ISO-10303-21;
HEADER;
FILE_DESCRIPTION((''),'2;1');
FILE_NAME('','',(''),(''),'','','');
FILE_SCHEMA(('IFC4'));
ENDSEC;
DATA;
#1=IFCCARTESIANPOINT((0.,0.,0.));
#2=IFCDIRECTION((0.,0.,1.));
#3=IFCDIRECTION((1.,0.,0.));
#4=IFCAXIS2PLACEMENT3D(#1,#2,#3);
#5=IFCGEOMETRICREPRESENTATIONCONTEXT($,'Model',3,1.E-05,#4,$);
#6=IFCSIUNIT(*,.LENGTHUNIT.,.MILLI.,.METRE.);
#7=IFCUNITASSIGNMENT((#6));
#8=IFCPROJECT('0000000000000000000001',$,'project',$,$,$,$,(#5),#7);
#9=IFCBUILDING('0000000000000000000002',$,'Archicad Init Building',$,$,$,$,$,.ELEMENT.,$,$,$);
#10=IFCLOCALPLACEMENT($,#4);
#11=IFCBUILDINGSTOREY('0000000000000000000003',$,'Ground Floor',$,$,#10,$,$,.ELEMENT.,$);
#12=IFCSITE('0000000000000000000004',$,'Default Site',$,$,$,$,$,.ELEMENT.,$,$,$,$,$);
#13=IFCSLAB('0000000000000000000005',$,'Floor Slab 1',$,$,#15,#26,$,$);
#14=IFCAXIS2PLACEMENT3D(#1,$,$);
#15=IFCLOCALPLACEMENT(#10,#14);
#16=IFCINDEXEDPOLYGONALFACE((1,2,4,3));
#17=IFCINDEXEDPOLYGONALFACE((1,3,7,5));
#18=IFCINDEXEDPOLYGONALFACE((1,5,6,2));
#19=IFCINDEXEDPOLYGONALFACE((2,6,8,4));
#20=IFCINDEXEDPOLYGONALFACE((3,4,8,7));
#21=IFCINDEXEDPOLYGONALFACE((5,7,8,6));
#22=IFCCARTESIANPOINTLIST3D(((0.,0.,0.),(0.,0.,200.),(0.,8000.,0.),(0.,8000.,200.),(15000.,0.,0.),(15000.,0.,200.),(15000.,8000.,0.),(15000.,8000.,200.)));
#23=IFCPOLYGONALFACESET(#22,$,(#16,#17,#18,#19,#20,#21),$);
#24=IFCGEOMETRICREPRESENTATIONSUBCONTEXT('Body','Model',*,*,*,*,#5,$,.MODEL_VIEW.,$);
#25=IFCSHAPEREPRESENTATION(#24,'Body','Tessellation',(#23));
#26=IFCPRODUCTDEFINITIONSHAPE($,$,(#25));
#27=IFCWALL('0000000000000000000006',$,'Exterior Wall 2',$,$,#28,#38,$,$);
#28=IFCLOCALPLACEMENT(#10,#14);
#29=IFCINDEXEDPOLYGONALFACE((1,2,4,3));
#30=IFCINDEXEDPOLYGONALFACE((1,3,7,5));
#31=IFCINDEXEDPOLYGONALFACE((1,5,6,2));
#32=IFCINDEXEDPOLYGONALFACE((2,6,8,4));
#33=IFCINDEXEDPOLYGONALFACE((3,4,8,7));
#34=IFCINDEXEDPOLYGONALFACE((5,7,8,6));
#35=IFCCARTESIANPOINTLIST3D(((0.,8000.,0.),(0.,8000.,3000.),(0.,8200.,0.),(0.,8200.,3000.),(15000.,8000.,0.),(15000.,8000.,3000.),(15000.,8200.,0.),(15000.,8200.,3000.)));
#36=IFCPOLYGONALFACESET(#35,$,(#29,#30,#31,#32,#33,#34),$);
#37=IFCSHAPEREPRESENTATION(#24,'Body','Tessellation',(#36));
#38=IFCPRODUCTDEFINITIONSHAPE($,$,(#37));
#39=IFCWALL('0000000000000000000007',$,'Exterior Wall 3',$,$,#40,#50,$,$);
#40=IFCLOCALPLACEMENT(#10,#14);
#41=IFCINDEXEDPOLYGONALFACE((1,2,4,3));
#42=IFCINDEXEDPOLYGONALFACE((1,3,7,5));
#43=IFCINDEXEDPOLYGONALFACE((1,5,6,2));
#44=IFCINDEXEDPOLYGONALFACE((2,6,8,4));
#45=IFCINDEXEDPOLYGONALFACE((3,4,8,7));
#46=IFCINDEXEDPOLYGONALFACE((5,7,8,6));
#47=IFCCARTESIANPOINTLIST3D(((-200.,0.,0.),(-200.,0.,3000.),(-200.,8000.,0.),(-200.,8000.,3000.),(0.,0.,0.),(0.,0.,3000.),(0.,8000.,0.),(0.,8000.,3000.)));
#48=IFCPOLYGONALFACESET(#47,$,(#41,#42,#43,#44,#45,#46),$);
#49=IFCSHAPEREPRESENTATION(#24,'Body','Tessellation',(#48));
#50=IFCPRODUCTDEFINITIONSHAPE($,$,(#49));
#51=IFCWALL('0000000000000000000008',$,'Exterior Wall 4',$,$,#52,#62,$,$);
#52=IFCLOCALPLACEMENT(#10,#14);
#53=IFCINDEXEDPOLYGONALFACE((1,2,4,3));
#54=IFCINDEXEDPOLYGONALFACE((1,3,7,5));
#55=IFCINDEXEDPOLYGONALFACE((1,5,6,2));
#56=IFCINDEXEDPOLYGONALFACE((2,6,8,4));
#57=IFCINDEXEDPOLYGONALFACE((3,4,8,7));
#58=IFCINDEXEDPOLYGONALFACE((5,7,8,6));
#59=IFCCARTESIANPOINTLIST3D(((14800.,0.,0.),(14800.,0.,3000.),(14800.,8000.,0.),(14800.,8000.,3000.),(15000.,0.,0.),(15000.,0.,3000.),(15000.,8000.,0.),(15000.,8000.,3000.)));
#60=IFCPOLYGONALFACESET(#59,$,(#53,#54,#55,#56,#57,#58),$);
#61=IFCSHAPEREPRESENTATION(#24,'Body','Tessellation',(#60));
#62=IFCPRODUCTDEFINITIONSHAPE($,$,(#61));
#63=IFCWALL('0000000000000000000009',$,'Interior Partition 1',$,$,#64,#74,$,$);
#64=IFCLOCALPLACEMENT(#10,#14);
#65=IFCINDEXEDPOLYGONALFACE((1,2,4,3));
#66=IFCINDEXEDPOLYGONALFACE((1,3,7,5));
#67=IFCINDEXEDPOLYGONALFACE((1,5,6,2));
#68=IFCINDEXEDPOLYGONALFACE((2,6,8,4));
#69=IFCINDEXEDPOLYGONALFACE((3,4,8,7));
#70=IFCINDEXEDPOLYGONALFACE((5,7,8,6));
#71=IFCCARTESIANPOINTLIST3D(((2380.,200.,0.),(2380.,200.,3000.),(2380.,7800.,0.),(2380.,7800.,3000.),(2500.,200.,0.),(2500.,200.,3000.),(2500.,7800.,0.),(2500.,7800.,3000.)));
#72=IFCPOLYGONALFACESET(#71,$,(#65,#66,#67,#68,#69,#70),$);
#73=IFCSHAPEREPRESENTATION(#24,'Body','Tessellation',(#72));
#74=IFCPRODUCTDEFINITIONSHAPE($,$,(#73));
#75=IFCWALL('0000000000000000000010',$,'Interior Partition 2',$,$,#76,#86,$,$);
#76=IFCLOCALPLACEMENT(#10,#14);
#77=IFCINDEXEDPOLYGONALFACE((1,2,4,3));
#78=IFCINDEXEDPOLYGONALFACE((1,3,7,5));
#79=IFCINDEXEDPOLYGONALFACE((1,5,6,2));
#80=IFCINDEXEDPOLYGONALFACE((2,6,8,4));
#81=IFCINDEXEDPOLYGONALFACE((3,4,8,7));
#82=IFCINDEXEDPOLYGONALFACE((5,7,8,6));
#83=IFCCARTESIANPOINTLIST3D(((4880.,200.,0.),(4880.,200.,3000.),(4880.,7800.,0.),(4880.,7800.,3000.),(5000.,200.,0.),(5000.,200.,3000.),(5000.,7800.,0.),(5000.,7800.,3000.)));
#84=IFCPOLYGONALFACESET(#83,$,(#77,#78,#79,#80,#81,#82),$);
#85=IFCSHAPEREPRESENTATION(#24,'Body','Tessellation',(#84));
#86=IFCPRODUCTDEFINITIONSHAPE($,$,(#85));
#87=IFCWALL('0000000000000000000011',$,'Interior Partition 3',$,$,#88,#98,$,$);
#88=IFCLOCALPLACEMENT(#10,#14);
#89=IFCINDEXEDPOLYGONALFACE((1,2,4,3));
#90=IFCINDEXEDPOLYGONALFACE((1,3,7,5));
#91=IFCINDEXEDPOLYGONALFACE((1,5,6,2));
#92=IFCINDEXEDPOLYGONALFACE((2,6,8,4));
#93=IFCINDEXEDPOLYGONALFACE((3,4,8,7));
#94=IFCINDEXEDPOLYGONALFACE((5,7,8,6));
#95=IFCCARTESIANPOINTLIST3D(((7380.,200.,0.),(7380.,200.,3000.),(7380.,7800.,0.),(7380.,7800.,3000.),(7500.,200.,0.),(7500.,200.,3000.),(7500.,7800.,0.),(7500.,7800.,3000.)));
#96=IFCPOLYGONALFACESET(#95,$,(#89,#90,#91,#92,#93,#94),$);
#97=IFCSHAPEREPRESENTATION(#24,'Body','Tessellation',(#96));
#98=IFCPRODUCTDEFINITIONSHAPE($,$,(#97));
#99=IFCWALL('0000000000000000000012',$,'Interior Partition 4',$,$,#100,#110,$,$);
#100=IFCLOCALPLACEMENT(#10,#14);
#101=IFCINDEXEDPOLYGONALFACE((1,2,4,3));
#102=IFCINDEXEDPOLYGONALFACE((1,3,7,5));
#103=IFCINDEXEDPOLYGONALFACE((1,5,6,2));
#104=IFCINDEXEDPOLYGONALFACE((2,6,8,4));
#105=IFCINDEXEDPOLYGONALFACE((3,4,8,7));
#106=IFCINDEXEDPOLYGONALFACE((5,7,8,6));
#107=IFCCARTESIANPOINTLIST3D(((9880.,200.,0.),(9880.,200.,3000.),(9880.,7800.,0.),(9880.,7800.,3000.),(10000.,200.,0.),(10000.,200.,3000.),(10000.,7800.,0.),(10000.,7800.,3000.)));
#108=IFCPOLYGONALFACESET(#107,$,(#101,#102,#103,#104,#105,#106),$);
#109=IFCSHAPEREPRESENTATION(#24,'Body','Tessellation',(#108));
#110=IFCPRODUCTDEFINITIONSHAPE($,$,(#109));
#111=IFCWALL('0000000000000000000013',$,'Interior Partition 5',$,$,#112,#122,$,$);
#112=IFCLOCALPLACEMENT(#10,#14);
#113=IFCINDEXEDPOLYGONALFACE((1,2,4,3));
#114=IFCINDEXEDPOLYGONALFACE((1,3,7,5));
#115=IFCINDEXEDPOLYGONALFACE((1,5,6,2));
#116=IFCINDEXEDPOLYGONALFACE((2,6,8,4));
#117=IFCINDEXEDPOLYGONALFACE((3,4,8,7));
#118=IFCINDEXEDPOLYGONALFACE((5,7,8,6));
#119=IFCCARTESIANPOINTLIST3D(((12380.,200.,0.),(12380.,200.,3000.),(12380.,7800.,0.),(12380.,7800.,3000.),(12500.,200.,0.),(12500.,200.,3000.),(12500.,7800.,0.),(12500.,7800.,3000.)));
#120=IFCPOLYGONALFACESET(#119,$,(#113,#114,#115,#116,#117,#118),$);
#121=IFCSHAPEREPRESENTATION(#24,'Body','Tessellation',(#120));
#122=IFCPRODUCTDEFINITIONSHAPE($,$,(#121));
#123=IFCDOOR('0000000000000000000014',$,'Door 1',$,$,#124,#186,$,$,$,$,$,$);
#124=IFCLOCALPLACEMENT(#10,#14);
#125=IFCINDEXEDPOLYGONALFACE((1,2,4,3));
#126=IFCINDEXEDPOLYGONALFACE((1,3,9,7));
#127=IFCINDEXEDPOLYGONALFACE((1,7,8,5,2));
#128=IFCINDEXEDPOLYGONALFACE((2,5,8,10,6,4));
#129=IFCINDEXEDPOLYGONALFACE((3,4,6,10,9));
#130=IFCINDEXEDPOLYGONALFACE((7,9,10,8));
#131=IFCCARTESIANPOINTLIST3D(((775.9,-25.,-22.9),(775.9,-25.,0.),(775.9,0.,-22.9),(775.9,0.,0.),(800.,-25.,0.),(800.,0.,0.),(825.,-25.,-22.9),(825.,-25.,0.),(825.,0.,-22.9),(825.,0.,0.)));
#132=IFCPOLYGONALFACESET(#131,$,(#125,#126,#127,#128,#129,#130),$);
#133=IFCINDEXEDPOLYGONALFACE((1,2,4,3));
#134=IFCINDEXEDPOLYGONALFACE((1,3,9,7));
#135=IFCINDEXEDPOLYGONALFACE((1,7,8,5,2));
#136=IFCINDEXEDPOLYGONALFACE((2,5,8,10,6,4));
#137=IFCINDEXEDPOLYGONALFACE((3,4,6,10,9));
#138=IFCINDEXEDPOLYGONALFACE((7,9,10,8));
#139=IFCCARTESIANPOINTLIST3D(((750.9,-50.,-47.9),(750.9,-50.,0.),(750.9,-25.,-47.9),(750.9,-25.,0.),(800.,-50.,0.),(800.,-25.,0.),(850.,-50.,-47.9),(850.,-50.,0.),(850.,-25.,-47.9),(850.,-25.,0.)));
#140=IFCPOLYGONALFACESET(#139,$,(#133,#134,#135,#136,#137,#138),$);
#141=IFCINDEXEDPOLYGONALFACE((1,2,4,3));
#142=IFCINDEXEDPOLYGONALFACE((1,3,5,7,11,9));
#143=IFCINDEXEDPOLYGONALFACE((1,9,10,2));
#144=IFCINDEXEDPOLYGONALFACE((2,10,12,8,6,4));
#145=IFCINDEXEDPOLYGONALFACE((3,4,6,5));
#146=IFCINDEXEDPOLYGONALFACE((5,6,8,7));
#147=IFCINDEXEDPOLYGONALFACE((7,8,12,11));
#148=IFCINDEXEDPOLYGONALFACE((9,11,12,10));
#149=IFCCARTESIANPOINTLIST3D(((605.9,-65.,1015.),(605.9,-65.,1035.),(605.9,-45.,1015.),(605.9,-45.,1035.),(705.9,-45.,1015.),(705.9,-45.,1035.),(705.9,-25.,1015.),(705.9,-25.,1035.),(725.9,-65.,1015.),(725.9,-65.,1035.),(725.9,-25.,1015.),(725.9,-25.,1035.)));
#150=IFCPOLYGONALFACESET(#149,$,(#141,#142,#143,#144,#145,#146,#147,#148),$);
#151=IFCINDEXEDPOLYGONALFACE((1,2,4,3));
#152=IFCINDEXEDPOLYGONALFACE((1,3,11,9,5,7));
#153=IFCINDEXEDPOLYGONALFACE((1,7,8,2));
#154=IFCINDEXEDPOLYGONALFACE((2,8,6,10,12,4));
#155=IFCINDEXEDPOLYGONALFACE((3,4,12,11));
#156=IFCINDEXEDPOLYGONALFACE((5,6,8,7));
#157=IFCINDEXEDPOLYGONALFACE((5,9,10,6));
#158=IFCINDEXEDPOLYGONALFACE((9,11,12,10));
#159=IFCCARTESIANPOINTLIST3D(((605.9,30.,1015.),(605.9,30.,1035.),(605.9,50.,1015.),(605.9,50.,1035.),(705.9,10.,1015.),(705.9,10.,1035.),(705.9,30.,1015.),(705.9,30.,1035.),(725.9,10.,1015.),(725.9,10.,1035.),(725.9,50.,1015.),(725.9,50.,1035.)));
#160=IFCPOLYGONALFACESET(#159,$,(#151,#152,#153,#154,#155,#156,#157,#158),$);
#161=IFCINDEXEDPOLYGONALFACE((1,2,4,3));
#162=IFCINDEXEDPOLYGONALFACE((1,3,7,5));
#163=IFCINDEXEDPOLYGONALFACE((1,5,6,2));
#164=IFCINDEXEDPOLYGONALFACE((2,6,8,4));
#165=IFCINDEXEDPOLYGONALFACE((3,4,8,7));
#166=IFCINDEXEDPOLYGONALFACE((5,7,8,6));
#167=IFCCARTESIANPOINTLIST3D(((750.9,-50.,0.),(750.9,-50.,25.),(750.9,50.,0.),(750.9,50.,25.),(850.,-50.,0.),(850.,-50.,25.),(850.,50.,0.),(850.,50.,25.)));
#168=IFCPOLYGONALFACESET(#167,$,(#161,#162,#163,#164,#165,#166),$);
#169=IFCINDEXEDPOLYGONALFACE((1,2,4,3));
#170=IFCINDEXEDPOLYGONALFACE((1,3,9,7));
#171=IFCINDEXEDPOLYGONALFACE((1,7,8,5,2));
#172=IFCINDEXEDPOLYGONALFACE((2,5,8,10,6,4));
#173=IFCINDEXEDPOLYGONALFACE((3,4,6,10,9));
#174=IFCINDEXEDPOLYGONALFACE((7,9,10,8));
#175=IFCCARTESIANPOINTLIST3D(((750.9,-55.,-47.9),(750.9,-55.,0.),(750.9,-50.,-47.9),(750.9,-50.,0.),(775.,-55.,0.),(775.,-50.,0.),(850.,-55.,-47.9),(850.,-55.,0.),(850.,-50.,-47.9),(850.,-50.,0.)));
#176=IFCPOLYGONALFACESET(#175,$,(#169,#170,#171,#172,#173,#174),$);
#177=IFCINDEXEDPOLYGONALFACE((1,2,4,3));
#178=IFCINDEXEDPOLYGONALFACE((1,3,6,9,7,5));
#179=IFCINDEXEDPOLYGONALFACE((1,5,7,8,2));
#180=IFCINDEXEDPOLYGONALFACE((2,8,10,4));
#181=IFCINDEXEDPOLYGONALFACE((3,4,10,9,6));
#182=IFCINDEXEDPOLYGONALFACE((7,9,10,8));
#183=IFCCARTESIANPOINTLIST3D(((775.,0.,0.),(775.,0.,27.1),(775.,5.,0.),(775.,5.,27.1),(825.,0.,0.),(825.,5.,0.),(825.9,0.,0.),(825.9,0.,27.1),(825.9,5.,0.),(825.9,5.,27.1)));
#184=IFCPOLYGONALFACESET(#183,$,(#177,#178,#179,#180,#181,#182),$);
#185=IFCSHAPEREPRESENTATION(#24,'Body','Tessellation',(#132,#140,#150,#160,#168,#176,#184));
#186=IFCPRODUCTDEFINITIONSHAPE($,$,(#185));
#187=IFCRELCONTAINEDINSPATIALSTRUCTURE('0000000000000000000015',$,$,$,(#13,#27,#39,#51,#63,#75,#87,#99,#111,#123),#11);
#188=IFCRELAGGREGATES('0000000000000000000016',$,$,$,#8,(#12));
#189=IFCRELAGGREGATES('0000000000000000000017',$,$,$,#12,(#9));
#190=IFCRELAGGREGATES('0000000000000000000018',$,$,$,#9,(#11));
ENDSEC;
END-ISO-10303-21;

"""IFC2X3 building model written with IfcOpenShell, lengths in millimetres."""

from ifc_helpers import new_model, si_unit, frame, origin_with_axes, place, context, subcontext, project, spatial, polyline, outline, extrude, element, save


model = new_model("IFC2X3")

# Units and contexts
model_context = context("Model", 3, precision=1e-05, world=origin_with_axes())
body_context = subcontext(model_context, "Body", "Model", "MODEL_VIEW")
ifc_project = project(units=[si_unit("LENGTHUNIT", "METRE", prefix="MILLI")], contexts=[model_context])

# Site, building, storey
site = spatial("IfcSite", under=ifc_project, Name="Default Site", CompositionType="ELEMENT")
building = spatial("IfcBuilding", under=site, Name="Archicad Init Building", CompositionType="ELEMENT")
storey_placement = place(None, origin_with_axes())
storey = spatial("IfcBuildingStorey", under=building, at=storey_placement, Name="Ground Floor", CompositionType="ELEMENT")

# Slab
slab_placement = place(storey_placement, origin_with_axes())
element("IfcSlab", 1, at=slab_placement, inside=storey, Name="Floor Slab 1", context=body_context, shape_type="SweptSolid", body=[
    extrude(outline(polyline([(0.0, 0.0), (15000.0, 0.0), (15000.0, 8000.0), (0.0, 8000.0), (0.0, 0.0)])), origin_with_axes(), (0.0, 0.0, 1.0), 200.0),
])

# Walls
wall_placement = place(storey_placement, frame((0.0, 8000.0, 0.0), z_axis=(0.0, 0.0, 1.0), x_axis=(1.0, 0.0, 0.0)))
element("IfcWall", 2, at=wall_placement, inside=storey, Name="Exterior Wall 2", context=body_context, shape_type="SweptSolid", body=[
    extrude(outline(polyline([(0.0, 0.0), (0.0, 200.0), (15000.0, 200.0), (15000.0, 0.0), (0.0, 0.0)])), origin_with_axes(), (0.0, 0.0, 1.0), 3000.0),
])
for number, where, z_axis, x_axis, name in (
    (3, (0.0, 0.0, 0.0), (0.0, 0.0, 1.0), (0.0, 1.0, 0.0), "Exterior Wall 3"),
    (4, (15000.0, 0.0, 0.0), (0.0, 0.0, 1.0), (0.0, 1.0, 0.0), "Exterior Wall 4"),
):
    element("IfcWall", number, at=place(storey_placement, frame(where, z_axis=z_axis, x_axis=x_axis)), inside=storey, Name=name, context=body_context, shape_type="SweptSolid", body=[
        extrude(outline(polyline([(0.0, 0.0), (0.0, 200.0), (8000.0, 200.0), (8000.0, 0.0), (0.0, 0.0)])), origin_with_axes(), (0.0, 0.0, 1.0), 3000.0),
    ])
for number, where, z_axis, x_axis, name in (
    (5, (2500.0, 200.0, 0.0), (0.0, 0.0, 1.0), (0.0, 1.0, 0.0), "Interior Partition 1"),
    (6, (5000.0, 200.0, 0.0), (0.0, 0.0, 1.0), (0.0, 1.0, 0.0), "Interior Partition 2"),
    (7, (7500.0, 200.0, 0.0), (0.0, 0.0, 1.0), (0.0, 1.0, 0.0), "Interior Partition 3"),
    (8, (10000.0, 200.0, 0.0), (0.0, 0.0, 1.0), (0.0, 1.0, 0.0), "Interior Partition 4"),
    (9, (12500.0, 200.0, 0.0), (0.0, 0.0, 1.0), (0.0, 1.0, 0.0), "Interior Partition 5"),
):
    element("IfcWall", number, at=place(storey_placement, frame(where, z_axis=z_axis, x_axis=x_axis)), inside=storey, Name=name, context=body_context, shape_type="SweptSolid", body=[
        extrude(outline(polyline([(0.0, 0.0), (0.0, 120.0), (7600.0, 120.0), (7600.0, 0.0), (0.0, 0.0)])), origin_with_axes(), (0.0, 0.0, 1.0), 3000.0),
    ])

# Door
door_1_placement = place(storey_placement, frame((800.0, -50.0, 0.0), z_axis=(0.0, 0.0, 1.0), x_axis=(1.0, 0.0, 0.0)))
element("IfcDoor", 10, at=door_1_placement, inside=storey, Name="Door 1", context=body_context, shape_type="SweptSolid", body=[
    extrude(outline(polyline([(0.0, 0.0), (0.0, 2.1), (0.9, 2.1), (0.9, 0.0), (-24.1, 0.0), (-24.1, -22.9), (25.0, -22.9), (25.0, 0.0), (0.0, 0.0)])), frame((0.0, 25.0, 0.0), z_axis=(0.0, -1.0, 0.0), x_axis=(1.0, 0.0, 0.0)), (0.0, 0.0, -1.0), 25.0),
    extrude(outline(polyline([(0.0, 0.0), (0.0, 2.1), (0.9, 2.1), (0.9, 0.0), (-49.1, 0.0), (-49.1, -47.9), (50.0, -47.9), (50.0, 0.0), (0.0, 0.0)])), frame((0.0, 0.0, 0.0), z_axis=(0.0, -1.0, 0.0), x_axis=(1.0, 0.0, 0.0)), (0.0, 0.0, -1.0), 25.0),
    extrude(outline(polyline([(0.0, 0.0), (-49.1, 0.0), (-49.1, 35.0), (0.0, 35.0), (0.0, 0.0)])), frame((25.0, 25.0, 25.0), z_axis=(0.0, 0.0, 1.0), x_axis=(1.0, 0.0, 0.0)), (0.0, 0.0, 1.0), -47.9),
    extrude(outline(polyline([(0.0, 0.0), (0.0, -40.0), (-120.0, -40.0), (-120.0, -20.0), (-20.0, -20.0), (-20.0, 0.0), (0.0, 0.0)])), frame((-74.1, 25.0, 1015.0), z_axis=(0.0, 0.0, 1.0), x_axis=(1.0, 0.0, 0.0)), (0.0, 0.0, 1.0), 20.0),
    extrude(outline(polyline([(0.0, 0.0), (0.0, 40.0), (-120.0, 40.0), (-120.0, 20.0), (-20.0, 20.0), (-20.0, 0.0), (0.0, 0.0)])), frame((-74.1, 60.0, 1015.0), z_axis=(0.0, 0.0, 1.0), x_axis=(1.0, 0.0, 0.0)), (0.0, 0.0, 1.0), 20.0),
    extrude(outline(polyline([(0.0, 0.0), (-99.1, 0.0), (-99.1, 100.0), (0.0, 100.0), (0.0, 0.0)])), frame((50.0, 0.0, 0.0), z_axis=(0.0, 0.0, 1.0), x_axis=(1.0, 0.0, 0.0)), (0.0, 0.0, 1.0), 25.0),
    extrude(outline(polyline([(0.0, 0.0), (0.0, 27.1), (50.9, 27.1), (50.9, 0.0), (-24.1, 0.0), (-24.1, -47.9), (75.0, -47.9), (75.0, 0.0), (0.0, 0.0)])), frame((-25.0, -5.0, 0.0), z_axis=(0.0, -1.0, 0.0), x_axis=(1.0, 0.0, 0.0)), (0.0, 0.0, -1.0), 5.0),
    extrude(outline(polyline([(0.0, 0.0), (0.0, 27.1), (50.9, 27.1), (50.9, 0.0), (0.9, 0.0), (0.9, -22.9), (50.0, -22.9), (50.0, 0.0), (0.0, 0.0)])), frame((-25.0, 50.0, 0.0), z_axis=(0.0, -1.0, 0.0), x_axis=(1.0, 0.0, 0.0)), (0.0, 0.0, -1.0), 5.0),
])

save(model, "model.ifc")
